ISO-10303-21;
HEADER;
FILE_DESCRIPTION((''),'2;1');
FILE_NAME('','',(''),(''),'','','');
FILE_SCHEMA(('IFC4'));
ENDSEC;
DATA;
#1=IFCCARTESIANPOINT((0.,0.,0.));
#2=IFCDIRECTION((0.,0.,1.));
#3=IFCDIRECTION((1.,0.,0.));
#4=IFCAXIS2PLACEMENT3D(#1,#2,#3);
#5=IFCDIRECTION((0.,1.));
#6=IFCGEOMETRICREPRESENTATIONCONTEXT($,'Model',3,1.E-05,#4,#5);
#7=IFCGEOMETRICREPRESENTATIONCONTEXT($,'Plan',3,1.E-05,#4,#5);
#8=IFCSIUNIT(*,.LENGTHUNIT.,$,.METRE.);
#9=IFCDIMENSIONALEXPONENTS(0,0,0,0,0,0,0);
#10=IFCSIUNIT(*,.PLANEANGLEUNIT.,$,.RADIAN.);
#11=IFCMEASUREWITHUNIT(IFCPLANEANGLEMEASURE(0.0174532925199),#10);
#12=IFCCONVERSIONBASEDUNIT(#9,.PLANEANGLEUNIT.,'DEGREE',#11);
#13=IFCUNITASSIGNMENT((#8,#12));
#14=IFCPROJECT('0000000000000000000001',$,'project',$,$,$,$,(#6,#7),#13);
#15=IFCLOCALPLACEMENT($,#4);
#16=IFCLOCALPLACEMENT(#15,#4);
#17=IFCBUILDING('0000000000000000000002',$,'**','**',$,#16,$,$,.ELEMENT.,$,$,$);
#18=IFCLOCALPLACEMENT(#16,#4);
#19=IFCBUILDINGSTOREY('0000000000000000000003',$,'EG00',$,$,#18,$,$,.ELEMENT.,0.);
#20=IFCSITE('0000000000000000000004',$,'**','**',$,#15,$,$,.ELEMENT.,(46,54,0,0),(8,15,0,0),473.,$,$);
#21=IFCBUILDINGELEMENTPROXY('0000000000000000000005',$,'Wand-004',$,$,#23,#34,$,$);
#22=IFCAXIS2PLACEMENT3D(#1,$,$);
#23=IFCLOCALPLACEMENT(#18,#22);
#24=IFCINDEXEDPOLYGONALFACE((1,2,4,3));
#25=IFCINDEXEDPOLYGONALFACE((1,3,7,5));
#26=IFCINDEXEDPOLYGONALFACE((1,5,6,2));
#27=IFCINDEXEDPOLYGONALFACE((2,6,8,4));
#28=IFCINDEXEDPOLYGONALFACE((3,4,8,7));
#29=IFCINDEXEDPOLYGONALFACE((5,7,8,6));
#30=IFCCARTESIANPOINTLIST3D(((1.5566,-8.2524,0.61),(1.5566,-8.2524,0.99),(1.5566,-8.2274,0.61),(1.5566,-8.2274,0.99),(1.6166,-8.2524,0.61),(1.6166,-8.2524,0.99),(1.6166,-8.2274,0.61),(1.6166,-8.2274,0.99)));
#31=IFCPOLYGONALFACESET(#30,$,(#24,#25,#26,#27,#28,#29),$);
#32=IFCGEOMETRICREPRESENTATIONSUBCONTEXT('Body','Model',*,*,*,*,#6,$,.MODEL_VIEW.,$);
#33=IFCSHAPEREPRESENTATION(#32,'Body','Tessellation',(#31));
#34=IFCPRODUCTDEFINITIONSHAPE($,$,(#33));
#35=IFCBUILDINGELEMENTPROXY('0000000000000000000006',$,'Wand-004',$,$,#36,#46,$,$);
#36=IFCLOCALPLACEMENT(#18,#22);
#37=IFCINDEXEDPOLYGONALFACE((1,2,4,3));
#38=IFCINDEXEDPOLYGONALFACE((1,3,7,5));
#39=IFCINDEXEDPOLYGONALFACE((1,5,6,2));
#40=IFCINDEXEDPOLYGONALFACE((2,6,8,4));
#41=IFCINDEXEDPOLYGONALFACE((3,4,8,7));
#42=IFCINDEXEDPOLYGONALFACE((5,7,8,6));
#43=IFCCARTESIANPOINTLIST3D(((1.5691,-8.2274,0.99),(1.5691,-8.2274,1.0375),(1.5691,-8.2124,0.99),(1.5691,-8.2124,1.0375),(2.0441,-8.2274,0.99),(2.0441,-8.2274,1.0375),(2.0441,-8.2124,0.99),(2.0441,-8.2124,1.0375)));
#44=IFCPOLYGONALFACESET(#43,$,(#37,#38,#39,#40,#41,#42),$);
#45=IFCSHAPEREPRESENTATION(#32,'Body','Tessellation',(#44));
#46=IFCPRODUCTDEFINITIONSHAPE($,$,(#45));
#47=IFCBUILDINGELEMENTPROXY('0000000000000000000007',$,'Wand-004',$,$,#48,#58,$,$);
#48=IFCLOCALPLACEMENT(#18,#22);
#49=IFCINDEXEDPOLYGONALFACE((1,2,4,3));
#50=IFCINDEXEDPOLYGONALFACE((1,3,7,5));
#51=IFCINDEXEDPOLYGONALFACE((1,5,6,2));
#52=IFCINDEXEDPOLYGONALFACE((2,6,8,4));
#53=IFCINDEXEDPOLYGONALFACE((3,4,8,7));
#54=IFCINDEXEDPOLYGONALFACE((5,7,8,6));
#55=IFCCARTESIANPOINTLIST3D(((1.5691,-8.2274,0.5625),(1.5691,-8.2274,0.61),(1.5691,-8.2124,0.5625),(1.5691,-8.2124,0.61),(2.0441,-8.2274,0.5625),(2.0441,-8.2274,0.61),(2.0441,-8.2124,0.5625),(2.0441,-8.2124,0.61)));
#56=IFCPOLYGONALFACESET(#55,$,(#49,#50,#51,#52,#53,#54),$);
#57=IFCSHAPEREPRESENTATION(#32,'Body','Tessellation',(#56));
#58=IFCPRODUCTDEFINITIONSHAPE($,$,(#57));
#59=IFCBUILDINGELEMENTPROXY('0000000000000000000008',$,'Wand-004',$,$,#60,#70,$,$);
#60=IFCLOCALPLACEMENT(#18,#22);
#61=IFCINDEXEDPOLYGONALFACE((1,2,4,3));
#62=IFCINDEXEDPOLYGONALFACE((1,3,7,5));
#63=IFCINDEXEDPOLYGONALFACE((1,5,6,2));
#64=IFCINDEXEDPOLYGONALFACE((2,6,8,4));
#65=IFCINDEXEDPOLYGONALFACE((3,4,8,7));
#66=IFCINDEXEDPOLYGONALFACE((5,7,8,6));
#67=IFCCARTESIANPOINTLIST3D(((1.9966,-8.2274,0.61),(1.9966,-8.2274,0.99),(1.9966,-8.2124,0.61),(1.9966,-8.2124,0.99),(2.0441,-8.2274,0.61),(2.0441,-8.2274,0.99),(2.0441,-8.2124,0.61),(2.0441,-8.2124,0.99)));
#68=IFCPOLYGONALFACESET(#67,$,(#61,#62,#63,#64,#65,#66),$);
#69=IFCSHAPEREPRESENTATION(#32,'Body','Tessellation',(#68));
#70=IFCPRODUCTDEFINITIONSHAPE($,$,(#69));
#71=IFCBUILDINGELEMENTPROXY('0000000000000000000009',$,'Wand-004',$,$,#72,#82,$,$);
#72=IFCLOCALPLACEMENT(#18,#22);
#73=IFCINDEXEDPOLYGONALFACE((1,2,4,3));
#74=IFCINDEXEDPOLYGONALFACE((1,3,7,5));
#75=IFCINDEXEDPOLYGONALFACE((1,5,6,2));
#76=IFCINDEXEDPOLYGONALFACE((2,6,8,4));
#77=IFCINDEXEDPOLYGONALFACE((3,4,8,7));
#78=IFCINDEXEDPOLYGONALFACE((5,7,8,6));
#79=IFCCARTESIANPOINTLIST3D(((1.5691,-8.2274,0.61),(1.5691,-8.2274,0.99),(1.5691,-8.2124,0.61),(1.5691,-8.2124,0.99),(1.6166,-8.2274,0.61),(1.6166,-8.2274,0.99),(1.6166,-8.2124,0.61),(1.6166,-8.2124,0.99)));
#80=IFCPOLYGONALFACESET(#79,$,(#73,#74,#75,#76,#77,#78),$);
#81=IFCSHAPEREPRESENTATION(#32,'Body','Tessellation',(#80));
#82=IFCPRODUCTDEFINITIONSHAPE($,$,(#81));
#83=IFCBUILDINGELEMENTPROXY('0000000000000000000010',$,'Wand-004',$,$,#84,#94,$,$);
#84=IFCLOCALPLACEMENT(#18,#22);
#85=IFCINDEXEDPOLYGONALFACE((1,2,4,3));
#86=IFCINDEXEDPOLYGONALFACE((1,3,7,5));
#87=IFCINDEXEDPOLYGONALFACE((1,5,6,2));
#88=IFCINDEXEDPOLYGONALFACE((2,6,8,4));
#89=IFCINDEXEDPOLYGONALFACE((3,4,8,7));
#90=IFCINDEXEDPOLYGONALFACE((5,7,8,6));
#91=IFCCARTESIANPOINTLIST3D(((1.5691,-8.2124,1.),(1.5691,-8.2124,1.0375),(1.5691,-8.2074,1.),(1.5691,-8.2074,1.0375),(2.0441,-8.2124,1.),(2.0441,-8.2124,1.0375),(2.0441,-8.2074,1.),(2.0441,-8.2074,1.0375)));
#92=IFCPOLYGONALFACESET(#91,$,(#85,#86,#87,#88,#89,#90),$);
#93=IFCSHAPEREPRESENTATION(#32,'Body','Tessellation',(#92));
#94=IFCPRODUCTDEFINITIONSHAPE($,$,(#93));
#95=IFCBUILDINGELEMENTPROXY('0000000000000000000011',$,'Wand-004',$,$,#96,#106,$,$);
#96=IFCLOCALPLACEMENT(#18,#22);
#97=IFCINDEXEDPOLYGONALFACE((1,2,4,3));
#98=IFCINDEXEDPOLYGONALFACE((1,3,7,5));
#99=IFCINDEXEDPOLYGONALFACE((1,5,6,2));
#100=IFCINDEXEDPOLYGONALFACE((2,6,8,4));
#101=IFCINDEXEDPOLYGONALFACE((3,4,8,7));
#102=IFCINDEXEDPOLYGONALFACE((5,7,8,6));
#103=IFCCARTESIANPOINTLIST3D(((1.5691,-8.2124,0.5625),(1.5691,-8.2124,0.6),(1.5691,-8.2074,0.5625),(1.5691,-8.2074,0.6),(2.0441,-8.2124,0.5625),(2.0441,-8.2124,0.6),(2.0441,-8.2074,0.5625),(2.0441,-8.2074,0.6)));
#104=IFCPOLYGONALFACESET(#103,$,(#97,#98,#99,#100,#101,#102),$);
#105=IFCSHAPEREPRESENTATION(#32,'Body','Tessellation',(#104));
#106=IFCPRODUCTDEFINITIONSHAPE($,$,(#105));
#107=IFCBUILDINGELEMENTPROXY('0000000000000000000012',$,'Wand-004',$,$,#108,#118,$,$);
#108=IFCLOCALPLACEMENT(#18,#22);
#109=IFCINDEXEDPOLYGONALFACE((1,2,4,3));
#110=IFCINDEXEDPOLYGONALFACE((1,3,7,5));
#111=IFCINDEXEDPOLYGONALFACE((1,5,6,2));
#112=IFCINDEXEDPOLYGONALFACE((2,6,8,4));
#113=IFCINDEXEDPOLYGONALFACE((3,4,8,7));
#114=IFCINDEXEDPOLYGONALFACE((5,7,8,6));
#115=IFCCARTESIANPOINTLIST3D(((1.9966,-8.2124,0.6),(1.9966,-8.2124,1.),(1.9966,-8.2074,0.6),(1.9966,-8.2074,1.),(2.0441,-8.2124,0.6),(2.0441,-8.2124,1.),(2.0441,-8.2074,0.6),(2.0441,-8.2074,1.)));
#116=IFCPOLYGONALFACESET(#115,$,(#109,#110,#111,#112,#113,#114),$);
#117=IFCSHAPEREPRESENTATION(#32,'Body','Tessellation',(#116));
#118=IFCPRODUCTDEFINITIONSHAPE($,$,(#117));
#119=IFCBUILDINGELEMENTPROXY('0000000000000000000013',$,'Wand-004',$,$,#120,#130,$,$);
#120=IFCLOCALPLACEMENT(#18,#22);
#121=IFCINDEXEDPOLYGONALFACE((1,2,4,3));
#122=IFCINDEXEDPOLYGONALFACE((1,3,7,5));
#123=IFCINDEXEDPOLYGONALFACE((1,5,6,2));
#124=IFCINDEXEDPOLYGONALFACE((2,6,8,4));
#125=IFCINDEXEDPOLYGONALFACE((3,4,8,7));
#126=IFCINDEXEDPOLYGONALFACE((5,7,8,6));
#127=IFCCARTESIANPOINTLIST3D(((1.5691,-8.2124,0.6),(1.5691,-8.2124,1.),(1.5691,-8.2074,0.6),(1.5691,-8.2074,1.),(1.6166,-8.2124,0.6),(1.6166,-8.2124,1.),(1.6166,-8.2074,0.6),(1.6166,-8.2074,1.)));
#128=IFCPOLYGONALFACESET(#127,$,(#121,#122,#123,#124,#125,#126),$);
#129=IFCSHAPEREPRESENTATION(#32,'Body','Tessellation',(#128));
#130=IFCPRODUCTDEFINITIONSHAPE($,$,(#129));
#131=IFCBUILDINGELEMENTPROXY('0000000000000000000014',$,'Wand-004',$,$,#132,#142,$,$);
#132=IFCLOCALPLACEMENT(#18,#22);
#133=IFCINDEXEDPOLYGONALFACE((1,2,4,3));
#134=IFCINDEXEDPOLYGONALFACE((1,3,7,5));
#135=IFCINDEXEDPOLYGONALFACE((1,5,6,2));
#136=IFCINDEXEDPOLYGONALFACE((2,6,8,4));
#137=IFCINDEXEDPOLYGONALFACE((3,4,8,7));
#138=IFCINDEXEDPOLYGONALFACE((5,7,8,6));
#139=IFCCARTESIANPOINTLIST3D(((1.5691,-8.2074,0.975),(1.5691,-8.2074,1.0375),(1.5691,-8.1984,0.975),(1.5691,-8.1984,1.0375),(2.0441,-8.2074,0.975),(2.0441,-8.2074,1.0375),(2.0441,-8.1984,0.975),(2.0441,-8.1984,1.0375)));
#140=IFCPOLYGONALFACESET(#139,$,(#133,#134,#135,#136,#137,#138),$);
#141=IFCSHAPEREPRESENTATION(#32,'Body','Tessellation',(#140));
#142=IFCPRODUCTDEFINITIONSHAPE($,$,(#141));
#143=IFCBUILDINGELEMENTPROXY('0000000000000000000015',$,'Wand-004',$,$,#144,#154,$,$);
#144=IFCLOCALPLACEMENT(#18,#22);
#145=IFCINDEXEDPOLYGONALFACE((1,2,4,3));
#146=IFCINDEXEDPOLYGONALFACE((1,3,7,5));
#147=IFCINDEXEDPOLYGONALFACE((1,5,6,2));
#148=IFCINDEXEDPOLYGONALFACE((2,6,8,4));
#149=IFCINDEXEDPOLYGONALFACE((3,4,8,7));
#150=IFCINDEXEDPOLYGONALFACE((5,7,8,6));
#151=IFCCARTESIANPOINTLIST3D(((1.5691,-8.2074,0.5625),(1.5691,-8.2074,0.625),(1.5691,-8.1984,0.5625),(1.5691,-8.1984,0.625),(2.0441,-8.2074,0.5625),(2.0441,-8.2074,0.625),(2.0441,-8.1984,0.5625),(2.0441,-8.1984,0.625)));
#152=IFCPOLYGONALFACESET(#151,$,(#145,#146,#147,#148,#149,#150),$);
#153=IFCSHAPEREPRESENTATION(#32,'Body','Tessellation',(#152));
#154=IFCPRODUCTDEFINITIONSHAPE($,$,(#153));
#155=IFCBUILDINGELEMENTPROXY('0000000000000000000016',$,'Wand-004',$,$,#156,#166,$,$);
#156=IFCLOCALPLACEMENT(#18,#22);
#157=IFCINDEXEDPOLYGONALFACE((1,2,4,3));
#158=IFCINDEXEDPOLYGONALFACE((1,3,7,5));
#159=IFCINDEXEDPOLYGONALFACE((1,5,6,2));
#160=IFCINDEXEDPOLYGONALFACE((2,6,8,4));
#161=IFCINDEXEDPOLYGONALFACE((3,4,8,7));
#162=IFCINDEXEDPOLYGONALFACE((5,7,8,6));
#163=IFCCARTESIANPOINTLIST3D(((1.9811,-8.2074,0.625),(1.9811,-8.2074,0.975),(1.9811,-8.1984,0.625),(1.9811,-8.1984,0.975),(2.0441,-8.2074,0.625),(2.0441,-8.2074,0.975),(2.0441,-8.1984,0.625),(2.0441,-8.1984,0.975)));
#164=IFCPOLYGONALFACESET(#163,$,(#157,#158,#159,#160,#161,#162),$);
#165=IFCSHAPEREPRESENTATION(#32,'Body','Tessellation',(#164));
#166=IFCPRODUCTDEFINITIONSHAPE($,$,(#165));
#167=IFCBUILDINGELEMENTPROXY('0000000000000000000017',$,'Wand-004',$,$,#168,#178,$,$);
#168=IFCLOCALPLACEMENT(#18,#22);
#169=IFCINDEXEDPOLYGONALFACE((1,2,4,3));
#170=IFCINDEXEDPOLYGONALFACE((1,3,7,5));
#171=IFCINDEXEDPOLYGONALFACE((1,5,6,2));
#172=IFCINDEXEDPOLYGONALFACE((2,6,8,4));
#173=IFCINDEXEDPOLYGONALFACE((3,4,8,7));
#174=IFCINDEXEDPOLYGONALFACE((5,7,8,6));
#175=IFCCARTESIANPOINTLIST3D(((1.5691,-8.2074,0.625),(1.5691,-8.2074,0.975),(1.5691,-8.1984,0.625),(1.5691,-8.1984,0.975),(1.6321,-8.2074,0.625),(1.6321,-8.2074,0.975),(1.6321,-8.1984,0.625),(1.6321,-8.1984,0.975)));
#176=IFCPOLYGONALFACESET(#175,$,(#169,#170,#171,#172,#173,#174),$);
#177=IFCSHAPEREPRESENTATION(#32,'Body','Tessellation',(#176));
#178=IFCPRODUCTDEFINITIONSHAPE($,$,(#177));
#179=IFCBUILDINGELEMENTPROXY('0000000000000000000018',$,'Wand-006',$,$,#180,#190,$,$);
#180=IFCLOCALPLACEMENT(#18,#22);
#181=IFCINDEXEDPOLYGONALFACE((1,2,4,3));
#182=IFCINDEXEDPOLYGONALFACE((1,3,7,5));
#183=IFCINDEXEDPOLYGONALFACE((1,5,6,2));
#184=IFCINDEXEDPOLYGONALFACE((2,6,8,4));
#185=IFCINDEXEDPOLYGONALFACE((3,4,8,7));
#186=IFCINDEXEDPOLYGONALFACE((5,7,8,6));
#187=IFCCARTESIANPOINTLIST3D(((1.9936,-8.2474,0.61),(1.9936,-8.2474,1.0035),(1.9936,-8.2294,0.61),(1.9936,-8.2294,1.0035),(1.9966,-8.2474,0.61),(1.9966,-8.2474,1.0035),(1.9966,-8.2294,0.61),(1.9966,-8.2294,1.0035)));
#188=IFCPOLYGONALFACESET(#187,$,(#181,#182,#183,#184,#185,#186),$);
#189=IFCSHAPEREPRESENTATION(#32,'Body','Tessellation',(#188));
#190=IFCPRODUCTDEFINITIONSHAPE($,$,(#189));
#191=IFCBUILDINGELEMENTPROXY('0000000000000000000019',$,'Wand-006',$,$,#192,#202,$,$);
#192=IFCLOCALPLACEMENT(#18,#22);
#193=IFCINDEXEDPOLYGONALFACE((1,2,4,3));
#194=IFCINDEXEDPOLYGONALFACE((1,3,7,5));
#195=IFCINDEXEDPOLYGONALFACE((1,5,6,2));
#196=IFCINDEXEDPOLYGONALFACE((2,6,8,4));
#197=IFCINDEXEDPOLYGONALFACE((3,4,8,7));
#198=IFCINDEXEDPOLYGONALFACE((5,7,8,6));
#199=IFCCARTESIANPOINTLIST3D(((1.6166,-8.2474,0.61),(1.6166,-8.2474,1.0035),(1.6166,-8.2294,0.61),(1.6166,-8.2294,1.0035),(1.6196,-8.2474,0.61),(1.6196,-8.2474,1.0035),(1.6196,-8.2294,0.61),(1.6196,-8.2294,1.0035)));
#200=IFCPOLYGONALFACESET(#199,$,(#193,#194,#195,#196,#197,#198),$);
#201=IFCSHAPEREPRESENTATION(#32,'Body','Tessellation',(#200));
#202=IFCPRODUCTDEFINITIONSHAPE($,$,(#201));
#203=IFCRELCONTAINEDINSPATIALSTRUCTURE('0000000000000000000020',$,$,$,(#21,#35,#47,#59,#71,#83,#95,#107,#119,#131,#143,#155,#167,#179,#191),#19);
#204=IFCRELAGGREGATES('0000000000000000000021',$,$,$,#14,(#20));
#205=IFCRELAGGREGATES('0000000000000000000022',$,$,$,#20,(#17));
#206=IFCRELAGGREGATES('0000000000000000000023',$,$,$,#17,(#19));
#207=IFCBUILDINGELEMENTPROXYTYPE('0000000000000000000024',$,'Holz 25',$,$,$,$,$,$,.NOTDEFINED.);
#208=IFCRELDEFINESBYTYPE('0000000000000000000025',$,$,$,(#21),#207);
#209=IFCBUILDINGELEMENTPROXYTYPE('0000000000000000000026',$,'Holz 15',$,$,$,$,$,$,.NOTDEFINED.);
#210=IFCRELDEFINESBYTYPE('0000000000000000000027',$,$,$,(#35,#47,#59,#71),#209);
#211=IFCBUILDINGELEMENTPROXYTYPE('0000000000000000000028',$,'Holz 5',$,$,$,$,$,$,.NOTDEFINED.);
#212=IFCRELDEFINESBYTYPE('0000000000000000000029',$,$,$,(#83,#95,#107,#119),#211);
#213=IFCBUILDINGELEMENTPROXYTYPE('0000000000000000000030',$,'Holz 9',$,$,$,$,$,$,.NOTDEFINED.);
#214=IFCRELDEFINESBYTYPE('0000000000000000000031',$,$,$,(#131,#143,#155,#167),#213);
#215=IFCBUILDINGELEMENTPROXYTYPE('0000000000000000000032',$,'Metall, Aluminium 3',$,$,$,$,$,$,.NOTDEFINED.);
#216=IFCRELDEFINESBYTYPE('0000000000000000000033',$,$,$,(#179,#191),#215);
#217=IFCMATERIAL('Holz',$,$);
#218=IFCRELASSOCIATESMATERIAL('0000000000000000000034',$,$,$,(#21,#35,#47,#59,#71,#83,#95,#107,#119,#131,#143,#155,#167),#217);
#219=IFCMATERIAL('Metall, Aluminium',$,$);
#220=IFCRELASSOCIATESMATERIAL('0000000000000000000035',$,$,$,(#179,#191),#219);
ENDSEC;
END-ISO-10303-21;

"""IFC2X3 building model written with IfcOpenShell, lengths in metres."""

from ifc_helpers import new_model, entity, si_unit, converted_unit, direction, frame, origin_with_axes, place, context, subcontext, project, spatial, polyline, outline, extrude, material, type_object, element, save


model = new_model("IFC2X3")

# Units and contexts
model_context = context("Model", 3, precision=1e-05, world=origin_with_axes(), true_north=direction((0.0, 1.0)))
plan_context = context("Plan", 3, precision=1e-05, world=origin_with_axes(), true_north=direction((0.0, 1.0)))
body_context = subcontext(model_context, "Body", "Model", "MODEL_VIEW")
ifc_project = project(units=[si_unit("LENGTHUNIT", "METRE"), converted_unit("PLANEANGLEUNIT", "DEGREE", entity("IfcPlaneAngleMeasure", 0.0174532925199), si_unit("PLANEANGLEUNIT", "RADIAN"), dimensions=[0, 0, 0, 0, 0, 0, 0])], contexts=[model_context, plan_context])

# Site, building, storey
site_placement = place(None, origin_with_axes())
site = spatial("IfcSite", under=ifc_project, at=site_placement, Name="**", Description="**", CompositionType="ELEMENT", RefLatitude=(46, 54, 0, 0), RefLongitude=(8, 15, 0, 0), RefElevation=473.0)
building_placement = place(site_placement, origin_with_axes())
building = spatial("IfcBuilding", under=site, at=building_placement, Name="**", Description="**", CompositionType="ELEMENT")
storey_placement = place(building_placement, origin_with_axes())
storey = spatial("IfcBuildingStorey", under=building, at=storey_placement, Name="EG00", CompositionType="ELEMENT", Elevation=0.0)

# Building element proxies
ifc_material_1 = material(Name="Holz")
building_element_proxy_type_1 = type_object("IfcBuildingElementProxyType", Name="Holz 25", PredefinedType="NOTDEFINED")
for number, where, z_axis, x_axis, name in (
    (1, (1.5566, -8.2524, 0.61), (0.0, 0.0, 1.0), (1.0, 0.0, 0.0), "Wand-004"),
):
    element("IfcBuildingElementProxy", number, at=place(storey_placement, frame(where, z_axis=z_axis, x_axis=x_axis)), inside=storey, type_object=building_element_proxy_type_1, material=ifc_material_1, Name=name, context=body_context, shape_type="SweptSolid", body=[
        extrude(outline(polyline([(0.0, 0.0), (0.06, 0.0), (0.06, 0.025), (0.0, 0.025), (0.0, 0.0)])), origin_with_axes(), (0.0, 0.0, 1.0), 0.38),
    ])
building_element_proxy_type_2 = type_object("IfcBuildingElementProxyType", Name="Holz 15", PredefinedType="NOTDEFINED")
for number, where, z_axis, x_axis, name in (
    (2, (2.0441, -8.2124, 0.99), (0.0, 0.0, 1.0), (-1.0, 0.0, 0.0), "Wand-004"),
    (3, (2.0441, -8.2124, 0.5625), (0.0, 0.0, 1.0), (-1.0, 0.0, 0.0), "Wand-004"),
):
    element("IfcBuildingElementProxy", number, at=place(storey_placement, frame(where, z_axis=z_axis, x_axis=x_axis)), inside=storey, type_object=building_element_proxy_type_2, material=ifc_material_1, Name=name, context=body_context, shape_type="SweptSolid", body=[
        extrude(outline(polyline([(0.0, 0.0), (0.475, 0.0), (0.475, 0.015), (0.0, 0.015), (0.0, 0.0)])), origin_with_axes(), (0.0, 0.0, 1.0), 0.0475),
    ])
for number, where, z_axis, x_axis, name in (
    (4, (1.9966, -8.2274, 0.61), (0.0, 0.0, 1.0), (1.0, 0.0, 0.0), "Wand-004"),
    (5, (1.5691, -8.2274, 0.61), (0.0, 0.0, 1.0), (1.0, 0.0, 0.0), "Wand-004"),
):
    element("IfcBuildingElementProxy", number, at=place(storey_placement, frame(where, z_axis=z_axis, x_axis=x_axis)), inside=storey, type_object=building_element_proxy_type_2, material=ifc_material_1, Name=name, context=body_context, shape_type="SweptSolid", body=[
        extrude(outline(polyline([(0.0, 0.0), (0.0475, 0.0), (0.0475, 0.015), (0.0, 0.015), (0.0, 0.0)])), origin_with_axes(), (0.0, 0.0, 1.0), 0.38),
    ])
building_element_proxy_type_3 = type_object("IfcBuildingElementProxyType", Name="Holz 5", PredefinedType="NOTDEFINED")
for number, where, z_axis, x_axis, name in (
    (6, (2.0441, -8.2124, 1.0), (0.0, 0.0, 1.0), (-1.0, 0.0, 0.0), "Wand-004"),
    (7, (2.0441, -8.2124, 0.5625), (0.0, 0.0, 1.0), (-1.0, 0.0, 0.0), "Wand-004"),
):
    element("IfcBuildingElementProxy", number, at=place(storey_placement, frame(where, z_axis=z_axis, x_axis=x_axis)), inside=storey, type_object=building_element_proxy_type_3, material=ifc_material_1, Name=name, context=body_context, shape_type="SweptSolid", body=[
        extrude(outline(polyline([(0.0, -0.005), (0.475, -0.005), (0.475, 0.0), (0.0, 0.0), (0.0, -0.005)])), origin_with_axes(), (0.0, 0.0, 1.0), 0.0375),
    ])
for number, where, z_axis, x_axis, name in (
    (8, (1.9966, -8.2124, 0.6), (0.0, 0.0, 1.0), (1.0, 0.0, 0.0), "Wand-004"),
    (9, (1.5691, -8.2124, 0.6), (0.0, 0.0, 1.0), (1.0, 0.0, 0.0), "Wand-004"),
):
    element("IfcBuildingElementProxy", number, at=place(storey_placement, frame(where, z_axis=z_axis, x_axis=x_axis)), inside=storey, type_object=building_element_proxy_type_3, material=ifc_material_1, Name=name, context=body_context, shape_type="SweptSolid", body=[
        extrude(outline(polyline([(0.0, 0.0), (0.0475, 0.0), (0.0475, 0.005), (0.0, 0.005), (0.0, 0.0)])), origin_with_axes(), (0.0, 0.0, 1.0), 0.4),
    ])
building_element_proxy_type_4 = type_object("IfcBuildingElementProxyType", Name="Holz 9", PredefinedType="NOTDEFINED")
for number, where, z_axis, x_axis, name in (
    (10, (2.0441, -8.2074, 0.975), (0.0, 0.0, 1.0), (-1.0, 0.0, 0.0), "Wand-004"),
    (11, (2.0441, -8.2074, 0.5625), (0.0, 0.0, 1.0), (-1.0, 0.0, 0.0), "Wand-004"),
):
    element("IfcBuildingElementProxy", number, at=place(storey_placement, frame(where, z_axis=z_axis, x_axis=x_axis)), inside=storey, type_object=building_element_proxy_type_4, material=ifc_material_1, Name=name, context=body_context, shape_type="SweptSolid", body=[
        extrude(outline(polyline([(0.0, -0.009), (0.475, -0.009), (0.475, 0.0), (0.0, 0.0), (0.0, -0.009)])), origin_with_axes(), (0.0, 0.0, 1.0), 0.0625),
    ])
for number, where, z_axis, x_axis, name in (
    (12, (1.9811, -8.2074, 0.625), (0.0, 0.0, 1.0), (1.0, 0.0, 0.0), "Wand-004"),
    (13, (1.5691, -8.2074, 0.625), (0.0, 0.0, 1.0), (1.0, 0.0, 0.0), "Wand-004"),
):
    element("IfcBuildingElementProxy", number, at=place(storey_placement, frame(where, z_axis=z_axis, x_axis=x_axis)), inside=storey, type_object=building_element_proxy_type_4, material=ifc_material_1, Name=name, context=body_context, shape_type="SweptSolid", body=[
        extrude(outline(polyline([(0.0, 0.0), (0.063, 0.0), (0.063, 0.009), (0.0, 0.009), (0.0, 0.0)])), origin_with_axes(), (0.0, 0.0, 1.0), 0.35),
    ])
ifc_material_2 = material(Name="Metall, Aluminium")
building_element_proxy_type_5 = type_object("IfcBuildingElementProxyType", Name="Metall, Aluminium 3", PredefinedType="NOTDEFINED")
proxy_1_placement = place(storey_placement, frame((1.9966, -8.2294, 0.61), z_axis=(0.0, 0.0, 1.0), x_axis=(0.0, -1.0, 0.0)))
element("IfcBuildingElementProxy", 14, at=proxy_1_placement, inside=storey, type_object=building_element_proxy_type_5, material=ifc_material_2, Name="Wand-006", context=body_context, shape_type="SweptSolid", body=[
    extrude(outline(polyline([(0.0, -0.003), (0.018, -0.003), (0.018, 0.0), (0.0, 0.0), (0.0, -0.003)])), origin_with_axes(), (0.0, 0.0, 1.0), 0.3935),
])
proxy_2_placement = place(storey_placement, frame((1.6166, -8.2294, 0.61), z_axis=(0.0, 0.0, 1.0), x_axis=(0.0, -1.0, 0.0)))
element("IfcBuildingElementProxy", 15, at=proxy_2_placement, inside=storey, type_object=building_element_proxy_type_5, material=ifc_material_2, Name="Wand-006", context=body_context, shape_type="SweptSolid", body=[
    extrude(outline(polyline([(0.0, 0.0), (0.018, 0.0), (0.018, 0.003), (0.0, 0.003), (0.0, 0.0)])), origin_with_axes(), (0.0, 0.0, 1.0), 0.3935),
])

save(model, "model.ifc")
